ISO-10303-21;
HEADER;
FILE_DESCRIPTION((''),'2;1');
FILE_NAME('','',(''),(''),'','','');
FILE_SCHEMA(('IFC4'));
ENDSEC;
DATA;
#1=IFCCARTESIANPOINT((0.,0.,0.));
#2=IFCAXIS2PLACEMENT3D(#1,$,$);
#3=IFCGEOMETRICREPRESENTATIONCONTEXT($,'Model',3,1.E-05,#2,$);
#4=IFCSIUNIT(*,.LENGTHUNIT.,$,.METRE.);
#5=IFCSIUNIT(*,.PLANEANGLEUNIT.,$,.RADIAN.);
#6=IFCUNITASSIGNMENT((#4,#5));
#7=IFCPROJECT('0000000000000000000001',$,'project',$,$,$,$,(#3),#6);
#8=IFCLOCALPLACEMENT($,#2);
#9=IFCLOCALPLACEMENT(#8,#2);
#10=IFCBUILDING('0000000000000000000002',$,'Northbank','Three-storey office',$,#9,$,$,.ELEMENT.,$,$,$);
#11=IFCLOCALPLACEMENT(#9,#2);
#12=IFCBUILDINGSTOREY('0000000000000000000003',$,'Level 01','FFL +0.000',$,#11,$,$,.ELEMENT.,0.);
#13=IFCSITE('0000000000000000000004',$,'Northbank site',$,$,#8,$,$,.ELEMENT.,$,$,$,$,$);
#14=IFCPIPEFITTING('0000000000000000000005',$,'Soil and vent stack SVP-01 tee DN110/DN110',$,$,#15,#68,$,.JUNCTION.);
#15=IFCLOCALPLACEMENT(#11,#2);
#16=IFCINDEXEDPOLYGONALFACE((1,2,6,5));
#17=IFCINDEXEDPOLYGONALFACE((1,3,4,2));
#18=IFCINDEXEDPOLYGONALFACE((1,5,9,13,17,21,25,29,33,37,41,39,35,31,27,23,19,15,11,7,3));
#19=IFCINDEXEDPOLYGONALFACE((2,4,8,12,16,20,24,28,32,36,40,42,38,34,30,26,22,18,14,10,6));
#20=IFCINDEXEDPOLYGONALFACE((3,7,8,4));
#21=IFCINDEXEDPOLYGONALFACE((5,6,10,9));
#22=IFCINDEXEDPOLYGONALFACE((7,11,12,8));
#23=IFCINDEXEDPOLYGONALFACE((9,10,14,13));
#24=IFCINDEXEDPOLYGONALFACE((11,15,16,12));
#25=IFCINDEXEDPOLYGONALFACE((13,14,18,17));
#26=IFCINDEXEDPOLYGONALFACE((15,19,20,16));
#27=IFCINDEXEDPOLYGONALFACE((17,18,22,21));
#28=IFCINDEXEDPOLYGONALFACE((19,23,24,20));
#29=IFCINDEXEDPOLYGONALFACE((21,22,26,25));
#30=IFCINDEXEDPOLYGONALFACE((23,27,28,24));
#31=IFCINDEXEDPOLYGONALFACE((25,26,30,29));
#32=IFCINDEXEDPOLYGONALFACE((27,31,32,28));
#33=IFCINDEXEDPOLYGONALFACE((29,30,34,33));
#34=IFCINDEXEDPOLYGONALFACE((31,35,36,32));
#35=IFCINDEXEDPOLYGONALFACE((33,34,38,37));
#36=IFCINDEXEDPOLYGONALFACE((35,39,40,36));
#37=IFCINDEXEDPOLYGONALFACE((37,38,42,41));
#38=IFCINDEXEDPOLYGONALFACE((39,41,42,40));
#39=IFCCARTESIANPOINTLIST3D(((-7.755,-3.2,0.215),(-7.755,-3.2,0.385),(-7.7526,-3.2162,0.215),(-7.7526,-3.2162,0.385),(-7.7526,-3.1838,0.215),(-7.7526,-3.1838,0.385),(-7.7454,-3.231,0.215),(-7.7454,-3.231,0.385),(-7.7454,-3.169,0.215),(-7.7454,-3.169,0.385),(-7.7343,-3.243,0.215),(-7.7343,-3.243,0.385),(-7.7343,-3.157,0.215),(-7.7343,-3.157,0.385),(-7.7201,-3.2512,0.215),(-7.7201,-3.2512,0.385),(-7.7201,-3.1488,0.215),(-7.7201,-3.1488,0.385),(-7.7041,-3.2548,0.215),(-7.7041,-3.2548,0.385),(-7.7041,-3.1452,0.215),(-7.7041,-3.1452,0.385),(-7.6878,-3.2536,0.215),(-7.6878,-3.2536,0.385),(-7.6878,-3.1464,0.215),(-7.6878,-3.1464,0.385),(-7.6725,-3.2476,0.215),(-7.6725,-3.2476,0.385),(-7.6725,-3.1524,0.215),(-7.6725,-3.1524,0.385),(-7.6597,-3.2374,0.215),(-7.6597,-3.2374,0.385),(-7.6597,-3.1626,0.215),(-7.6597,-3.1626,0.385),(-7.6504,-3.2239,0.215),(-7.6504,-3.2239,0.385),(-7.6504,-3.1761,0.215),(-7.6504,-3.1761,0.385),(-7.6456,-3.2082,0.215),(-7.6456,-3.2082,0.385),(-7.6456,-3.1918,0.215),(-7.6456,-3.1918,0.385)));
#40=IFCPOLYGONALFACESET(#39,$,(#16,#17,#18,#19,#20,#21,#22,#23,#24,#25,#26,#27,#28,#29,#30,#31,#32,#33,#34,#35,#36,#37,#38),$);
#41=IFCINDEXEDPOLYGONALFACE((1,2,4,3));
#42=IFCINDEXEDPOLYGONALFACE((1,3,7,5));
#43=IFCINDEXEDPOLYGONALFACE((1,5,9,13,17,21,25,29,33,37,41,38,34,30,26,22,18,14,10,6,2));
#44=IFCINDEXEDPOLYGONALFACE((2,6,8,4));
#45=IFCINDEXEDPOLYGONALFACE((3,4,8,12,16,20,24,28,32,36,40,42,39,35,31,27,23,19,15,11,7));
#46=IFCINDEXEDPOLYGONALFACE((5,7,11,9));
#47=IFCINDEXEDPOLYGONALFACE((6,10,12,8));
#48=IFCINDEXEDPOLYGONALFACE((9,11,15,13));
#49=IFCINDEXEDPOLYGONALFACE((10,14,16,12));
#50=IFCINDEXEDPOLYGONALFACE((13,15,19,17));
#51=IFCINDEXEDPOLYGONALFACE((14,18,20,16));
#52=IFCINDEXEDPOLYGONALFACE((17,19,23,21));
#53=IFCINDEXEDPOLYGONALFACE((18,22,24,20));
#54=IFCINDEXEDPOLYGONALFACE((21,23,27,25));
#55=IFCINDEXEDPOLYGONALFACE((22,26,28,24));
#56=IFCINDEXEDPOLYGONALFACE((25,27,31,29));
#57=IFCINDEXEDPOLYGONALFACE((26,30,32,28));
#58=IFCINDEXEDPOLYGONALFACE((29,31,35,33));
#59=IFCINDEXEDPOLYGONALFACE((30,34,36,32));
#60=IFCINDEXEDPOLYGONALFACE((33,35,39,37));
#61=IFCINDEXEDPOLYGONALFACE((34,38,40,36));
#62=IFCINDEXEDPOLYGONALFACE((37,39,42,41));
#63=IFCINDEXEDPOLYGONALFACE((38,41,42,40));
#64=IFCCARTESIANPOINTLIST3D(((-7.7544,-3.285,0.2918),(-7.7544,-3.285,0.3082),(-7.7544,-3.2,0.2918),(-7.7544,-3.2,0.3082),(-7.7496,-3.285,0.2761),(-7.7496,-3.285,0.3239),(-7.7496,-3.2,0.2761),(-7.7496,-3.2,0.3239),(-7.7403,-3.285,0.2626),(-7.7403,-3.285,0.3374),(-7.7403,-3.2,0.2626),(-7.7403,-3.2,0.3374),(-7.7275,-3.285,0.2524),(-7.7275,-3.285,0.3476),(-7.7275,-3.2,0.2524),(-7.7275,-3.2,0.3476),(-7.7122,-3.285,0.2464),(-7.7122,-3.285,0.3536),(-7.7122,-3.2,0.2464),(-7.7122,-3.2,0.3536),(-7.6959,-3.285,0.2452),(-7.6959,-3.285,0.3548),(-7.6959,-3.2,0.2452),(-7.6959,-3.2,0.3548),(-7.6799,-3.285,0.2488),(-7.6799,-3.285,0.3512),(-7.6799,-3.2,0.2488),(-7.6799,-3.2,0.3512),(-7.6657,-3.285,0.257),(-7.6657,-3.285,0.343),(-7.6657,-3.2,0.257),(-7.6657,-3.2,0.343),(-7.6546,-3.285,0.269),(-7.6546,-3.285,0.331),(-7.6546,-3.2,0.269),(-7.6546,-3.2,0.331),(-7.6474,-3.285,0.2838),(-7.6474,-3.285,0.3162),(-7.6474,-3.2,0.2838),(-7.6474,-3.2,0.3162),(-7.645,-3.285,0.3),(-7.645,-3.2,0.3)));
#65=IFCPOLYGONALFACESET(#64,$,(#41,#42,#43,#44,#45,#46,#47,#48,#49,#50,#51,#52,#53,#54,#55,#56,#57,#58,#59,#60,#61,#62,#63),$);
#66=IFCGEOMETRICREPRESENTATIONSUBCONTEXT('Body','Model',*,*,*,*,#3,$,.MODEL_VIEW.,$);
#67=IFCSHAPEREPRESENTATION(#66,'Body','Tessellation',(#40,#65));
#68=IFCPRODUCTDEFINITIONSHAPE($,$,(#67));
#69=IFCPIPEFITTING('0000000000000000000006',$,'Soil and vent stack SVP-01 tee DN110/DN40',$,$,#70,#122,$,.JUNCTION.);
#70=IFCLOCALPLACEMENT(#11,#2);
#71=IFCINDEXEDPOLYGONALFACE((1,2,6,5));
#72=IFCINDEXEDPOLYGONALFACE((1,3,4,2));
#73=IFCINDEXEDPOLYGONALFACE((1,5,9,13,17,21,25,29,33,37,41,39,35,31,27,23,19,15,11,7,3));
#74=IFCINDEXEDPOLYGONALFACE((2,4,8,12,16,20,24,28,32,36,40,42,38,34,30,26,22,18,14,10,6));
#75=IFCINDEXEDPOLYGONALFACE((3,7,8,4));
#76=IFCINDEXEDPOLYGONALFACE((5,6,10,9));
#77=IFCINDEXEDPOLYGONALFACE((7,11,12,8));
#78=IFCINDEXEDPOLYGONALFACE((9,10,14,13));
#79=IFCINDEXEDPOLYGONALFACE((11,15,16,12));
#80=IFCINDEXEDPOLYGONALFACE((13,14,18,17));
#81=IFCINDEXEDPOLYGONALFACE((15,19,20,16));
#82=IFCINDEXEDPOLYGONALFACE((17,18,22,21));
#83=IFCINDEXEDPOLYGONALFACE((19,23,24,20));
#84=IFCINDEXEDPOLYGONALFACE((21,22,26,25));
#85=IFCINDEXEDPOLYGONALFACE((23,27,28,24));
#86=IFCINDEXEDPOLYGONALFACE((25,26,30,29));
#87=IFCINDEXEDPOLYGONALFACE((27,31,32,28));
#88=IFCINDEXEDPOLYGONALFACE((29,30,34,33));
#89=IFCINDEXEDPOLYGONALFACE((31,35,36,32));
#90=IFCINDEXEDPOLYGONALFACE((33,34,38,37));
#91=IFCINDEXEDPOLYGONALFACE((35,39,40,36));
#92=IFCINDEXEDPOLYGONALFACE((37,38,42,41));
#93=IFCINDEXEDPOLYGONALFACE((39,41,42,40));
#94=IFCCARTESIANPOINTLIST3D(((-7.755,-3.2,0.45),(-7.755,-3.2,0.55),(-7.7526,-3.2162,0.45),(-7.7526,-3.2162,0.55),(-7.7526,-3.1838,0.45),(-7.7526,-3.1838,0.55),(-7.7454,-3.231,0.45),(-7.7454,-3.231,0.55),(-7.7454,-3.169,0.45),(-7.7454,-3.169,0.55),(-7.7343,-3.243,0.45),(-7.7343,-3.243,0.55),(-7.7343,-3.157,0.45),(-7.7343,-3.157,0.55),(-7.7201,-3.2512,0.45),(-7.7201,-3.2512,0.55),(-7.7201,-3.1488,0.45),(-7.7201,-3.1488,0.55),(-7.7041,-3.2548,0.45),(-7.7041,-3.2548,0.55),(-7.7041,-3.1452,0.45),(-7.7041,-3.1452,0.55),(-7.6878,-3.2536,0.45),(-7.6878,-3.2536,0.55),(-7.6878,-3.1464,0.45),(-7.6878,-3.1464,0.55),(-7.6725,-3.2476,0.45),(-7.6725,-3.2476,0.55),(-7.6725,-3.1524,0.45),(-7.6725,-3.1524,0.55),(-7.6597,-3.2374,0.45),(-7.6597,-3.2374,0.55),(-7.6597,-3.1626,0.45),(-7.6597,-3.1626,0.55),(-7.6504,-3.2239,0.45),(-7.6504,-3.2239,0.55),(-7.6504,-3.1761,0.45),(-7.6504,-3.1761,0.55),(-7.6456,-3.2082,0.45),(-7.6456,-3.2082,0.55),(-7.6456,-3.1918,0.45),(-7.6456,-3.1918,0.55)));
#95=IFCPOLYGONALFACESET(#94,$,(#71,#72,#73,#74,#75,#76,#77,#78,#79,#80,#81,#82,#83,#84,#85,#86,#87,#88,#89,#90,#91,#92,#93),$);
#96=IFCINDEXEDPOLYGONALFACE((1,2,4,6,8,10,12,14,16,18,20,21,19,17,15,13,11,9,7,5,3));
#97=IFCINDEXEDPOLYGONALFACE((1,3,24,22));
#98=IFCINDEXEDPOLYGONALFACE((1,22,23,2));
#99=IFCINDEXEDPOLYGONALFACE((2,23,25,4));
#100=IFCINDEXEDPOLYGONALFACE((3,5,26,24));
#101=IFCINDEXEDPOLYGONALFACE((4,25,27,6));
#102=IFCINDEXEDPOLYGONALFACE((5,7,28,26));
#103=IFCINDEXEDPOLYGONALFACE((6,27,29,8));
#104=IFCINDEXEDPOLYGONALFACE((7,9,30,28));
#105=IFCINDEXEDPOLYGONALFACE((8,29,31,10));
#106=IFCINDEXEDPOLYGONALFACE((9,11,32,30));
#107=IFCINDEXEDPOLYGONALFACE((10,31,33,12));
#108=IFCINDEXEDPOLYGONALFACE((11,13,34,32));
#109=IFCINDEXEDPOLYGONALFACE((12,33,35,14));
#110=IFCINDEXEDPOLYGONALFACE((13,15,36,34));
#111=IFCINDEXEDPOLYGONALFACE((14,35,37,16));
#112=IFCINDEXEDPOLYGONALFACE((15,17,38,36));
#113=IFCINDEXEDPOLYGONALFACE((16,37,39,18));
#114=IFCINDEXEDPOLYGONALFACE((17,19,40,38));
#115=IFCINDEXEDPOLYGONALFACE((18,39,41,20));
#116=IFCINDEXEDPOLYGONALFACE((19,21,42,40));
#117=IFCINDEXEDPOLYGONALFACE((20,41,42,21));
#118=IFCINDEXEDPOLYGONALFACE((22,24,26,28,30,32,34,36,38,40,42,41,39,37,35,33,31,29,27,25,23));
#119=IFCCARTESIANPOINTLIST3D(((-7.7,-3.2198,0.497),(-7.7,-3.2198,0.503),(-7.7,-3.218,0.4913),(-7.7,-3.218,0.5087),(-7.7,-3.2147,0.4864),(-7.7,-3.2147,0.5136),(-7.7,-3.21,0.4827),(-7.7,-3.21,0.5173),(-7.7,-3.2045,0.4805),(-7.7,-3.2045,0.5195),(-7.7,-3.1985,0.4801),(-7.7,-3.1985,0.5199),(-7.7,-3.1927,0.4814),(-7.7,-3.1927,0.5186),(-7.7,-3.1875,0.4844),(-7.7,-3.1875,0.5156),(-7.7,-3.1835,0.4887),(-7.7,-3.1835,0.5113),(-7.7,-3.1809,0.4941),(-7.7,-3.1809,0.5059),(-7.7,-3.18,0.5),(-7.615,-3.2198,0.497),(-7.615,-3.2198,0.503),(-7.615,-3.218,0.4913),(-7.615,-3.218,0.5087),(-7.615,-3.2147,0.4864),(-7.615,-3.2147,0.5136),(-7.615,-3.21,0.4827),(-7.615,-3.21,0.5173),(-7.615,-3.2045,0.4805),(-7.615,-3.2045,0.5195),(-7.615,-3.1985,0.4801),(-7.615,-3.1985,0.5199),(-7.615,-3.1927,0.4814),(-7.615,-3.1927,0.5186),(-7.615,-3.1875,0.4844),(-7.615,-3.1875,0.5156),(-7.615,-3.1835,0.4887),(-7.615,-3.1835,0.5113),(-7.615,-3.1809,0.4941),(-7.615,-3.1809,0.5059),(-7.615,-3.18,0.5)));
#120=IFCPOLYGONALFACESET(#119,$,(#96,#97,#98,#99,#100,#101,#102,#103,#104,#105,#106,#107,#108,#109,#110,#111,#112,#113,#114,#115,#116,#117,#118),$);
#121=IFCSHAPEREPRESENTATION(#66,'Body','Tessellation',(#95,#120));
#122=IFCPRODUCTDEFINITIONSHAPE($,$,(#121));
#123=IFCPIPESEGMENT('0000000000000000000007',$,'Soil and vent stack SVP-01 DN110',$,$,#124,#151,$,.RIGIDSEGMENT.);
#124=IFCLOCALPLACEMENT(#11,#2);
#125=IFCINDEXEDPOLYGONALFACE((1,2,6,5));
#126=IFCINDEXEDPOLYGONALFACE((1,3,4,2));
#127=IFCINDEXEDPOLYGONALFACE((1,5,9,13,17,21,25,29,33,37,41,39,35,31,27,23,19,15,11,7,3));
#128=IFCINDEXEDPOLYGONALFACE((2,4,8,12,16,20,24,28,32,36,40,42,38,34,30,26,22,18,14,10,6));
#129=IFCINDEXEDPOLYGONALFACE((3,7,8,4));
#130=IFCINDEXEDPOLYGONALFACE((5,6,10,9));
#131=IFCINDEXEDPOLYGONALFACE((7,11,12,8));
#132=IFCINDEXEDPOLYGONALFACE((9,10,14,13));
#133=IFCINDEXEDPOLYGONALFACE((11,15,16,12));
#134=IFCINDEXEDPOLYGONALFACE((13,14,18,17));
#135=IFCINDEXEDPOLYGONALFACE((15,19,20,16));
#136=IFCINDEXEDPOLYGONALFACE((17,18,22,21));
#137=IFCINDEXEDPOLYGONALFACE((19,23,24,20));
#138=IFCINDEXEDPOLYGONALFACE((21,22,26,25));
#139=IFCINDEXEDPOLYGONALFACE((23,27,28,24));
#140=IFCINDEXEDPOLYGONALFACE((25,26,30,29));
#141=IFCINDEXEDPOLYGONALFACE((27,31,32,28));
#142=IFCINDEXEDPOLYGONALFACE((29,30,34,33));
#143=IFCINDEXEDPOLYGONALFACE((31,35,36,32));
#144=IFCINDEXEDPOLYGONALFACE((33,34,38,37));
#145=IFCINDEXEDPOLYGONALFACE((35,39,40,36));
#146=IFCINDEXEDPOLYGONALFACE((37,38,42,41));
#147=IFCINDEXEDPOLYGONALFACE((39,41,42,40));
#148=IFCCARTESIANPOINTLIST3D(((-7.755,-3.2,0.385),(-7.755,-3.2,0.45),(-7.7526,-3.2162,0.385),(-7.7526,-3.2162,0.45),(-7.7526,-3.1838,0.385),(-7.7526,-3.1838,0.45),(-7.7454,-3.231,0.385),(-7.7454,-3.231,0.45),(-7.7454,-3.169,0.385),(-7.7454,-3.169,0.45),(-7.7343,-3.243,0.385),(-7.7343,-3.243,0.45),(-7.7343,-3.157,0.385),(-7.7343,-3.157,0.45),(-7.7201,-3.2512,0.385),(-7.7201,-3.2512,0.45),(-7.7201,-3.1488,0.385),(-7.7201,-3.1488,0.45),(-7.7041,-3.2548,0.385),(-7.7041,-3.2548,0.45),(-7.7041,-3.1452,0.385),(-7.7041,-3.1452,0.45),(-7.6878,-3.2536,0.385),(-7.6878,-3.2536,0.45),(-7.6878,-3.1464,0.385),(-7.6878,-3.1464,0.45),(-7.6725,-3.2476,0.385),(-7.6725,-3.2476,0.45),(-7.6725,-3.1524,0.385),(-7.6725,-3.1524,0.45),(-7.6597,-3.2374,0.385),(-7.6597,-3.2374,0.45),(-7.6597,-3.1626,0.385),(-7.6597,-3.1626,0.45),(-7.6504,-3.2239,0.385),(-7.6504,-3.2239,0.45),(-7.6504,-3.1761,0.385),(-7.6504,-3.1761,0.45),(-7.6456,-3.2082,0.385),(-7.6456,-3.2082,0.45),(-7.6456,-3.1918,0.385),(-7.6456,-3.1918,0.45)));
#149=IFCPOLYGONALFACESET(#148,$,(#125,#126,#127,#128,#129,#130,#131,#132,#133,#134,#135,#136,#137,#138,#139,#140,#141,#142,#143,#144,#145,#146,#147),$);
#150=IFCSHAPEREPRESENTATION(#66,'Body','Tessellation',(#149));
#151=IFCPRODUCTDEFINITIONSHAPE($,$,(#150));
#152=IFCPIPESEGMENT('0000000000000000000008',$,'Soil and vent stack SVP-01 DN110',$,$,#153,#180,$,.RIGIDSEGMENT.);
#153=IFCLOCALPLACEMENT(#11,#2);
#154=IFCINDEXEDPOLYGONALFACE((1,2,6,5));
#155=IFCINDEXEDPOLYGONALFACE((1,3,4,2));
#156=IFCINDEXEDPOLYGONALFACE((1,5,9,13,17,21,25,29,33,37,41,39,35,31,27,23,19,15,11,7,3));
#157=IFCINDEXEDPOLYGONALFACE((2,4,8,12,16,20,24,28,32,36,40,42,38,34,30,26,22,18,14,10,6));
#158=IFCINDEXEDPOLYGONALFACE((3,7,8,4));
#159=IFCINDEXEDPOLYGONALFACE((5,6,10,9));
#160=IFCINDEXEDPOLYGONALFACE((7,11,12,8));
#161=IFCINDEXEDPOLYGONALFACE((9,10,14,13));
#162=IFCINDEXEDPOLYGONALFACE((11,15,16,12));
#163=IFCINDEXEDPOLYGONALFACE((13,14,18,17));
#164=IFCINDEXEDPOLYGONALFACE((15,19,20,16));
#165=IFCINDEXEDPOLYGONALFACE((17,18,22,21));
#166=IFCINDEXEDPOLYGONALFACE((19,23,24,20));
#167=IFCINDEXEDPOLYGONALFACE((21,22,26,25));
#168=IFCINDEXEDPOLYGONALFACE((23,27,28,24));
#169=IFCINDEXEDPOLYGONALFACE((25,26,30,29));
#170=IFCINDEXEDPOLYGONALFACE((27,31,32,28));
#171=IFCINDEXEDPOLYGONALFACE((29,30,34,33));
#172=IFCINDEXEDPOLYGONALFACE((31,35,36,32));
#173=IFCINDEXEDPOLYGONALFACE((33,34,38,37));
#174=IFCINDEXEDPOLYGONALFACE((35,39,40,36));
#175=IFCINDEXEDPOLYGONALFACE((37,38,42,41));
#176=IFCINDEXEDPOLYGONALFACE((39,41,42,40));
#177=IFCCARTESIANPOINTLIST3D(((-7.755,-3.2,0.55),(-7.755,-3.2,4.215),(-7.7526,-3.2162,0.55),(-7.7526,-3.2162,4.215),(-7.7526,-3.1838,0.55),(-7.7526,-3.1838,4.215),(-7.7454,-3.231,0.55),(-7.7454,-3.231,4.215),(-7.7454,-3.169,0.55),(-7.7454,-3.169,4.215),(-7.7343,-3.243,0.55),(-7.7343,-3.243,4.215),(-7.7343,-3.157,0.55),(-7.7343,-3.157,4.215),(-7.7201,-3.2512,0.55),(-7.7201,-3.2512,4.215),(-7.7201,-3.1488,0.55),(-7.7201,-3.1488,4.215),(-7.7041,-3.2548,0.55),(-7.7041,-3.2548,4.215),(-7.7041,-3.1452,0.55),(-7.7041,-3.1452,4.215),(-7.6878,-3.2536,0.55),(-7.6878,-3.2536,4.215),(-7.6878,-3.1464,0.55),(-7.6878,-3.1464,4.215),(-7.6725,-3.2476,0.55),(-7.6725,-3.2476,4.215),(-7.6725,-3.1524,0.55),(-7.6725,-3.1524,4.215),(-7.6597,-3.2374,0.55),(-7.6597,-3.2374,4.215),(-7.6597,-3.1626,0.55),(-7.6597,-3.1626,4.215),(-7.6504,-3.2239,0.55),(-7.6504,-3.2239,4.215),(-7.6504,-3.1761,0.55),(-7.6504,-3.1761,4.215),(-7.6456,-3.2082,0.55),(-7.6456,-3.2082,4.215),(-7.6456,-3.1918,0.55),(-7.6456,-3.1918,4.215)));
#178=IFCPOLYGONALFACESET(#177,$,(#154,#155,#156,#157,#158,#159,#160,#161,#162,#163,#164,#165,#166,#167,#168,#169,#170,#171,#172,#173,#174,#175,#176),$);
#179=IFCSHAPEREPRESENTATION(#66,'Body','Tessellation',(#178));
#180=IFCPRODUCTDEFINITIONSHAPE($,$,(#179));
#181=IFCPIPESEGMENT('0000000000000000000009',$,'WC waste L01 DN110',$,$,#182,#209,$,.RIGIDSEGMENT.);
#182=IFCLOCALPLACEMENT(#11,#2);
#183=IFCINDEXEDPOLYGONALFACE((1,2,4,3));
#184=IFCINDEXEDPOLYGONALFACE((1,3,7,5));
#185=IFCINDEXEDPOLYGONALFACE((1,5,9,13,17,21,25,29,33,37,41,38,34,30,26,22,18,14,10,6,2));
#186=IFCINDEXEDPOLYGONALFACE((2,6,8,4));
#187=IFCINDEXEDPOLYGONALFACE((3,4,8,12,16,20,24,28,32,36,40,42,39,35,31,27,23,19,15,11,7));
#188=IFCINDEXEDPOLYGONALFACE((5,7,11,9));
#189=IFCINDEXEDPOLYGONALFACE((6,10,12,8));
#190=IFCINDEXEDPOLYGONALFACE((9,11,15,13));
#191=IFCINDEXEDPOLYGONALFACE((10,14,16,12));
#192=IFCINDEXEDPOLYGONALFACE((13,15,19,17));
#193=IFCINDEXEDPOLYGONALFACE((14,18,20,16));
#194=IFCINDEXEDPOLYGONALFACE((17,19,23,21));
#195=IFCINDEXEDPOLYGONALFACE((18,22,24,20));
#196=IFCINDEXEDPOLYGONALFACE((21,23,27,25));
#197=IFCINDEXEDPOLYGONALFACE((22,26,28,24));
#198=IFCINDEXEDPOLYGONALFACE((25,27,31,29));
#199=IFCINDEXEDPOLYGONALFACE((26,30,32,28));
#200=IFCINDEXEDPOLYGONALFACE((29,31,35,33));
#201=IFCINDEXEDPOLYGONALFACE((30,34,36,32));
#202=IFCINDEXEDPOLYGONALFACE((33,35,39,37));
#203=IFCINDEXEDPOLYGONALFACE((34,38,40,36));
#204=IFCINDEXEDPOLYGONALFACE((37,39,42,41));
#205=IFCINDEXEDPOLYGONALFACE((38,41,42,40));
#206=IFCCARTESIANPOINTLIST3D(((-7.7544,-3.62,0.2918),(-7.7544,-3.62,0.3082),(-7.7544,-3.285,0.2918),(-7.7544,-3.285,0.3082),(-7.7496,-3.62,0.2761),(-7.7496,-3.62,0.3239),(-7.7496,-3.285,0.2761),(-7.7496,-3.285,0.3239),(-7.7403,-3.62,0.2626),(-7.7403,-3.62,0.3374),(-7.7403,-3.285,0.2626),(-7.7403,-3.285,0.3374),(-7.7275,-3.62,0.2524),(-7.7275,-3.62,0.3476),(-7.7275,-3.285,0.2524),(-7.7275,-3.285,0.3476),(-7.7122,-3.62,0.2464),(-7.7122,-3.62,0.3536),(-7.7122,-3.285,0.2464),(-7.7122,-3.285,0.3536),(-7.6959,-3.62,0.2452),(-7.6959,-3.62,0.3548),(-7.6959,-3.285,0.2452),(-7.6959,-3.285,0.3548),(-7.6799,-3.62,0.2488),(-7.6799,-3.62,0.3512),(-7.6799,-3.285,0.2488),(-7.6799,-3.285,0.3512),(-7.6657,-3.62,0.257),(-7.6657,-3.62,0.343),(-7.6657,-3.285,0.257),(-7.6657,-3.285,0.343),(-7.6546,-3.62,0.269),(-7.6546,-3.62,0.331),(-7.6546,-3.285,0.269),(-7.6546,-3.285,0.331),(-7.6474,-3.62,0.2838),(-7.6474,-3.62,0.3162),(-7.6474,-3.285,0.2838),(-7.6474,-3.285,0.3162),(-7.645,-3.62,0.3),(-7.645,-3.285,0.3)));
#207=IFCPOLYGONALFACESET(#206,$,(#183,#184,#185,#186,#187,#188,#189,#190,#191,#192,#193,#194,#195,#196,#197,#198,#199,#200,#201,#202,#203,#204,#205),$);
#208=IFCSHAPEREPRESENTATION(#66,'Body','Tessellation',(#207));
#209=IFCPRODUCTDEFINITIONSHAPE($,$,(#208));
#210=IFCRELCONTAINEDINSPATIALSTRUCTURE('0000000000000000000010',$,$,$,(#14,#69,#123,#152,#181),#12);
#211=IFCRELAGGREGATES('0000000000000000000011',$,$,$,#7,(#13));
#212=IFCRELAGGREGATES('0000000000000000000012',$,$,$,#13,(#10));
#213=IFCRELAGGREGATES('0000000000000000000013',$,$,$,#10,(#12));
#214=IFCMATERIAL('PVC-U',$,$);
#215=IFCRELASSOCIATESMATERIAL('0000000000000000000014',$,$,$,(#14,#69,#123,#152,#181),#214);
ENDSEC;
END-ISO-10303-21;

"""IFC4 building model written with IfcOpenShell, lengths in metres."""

from ifc_helpers import new_model, si_unit, frame, origin, place, context, subcontext, project, spatial, circle, extrude, material, element, save


model = new_model("IFC4")

# Units and contexts
model_context = context("Model", 3, precision=1e-05, world=origin())
body_context = subcontext(model_context, "Body", "Model", "MODEL_VIEW")
ifc_project = project(units=[si_unit("LENGTHUNIT", "METRE"), si_unit("PLANEANGLEUNIT", "RADIAN")], contexts=[model_context])

# Site, building, storey
site_placement = place(None, origin())
site = spatial("IfcSite", under=ifc_project, at=site_placement, Name="Northbank site", CompositionType="ELEMENT")
building_placement = place(site_placement, origin())
building = spatial("IfcBuilding", under=site, at=building_placement, Name="Northbank", Description="Three-storey office", CompositionType="ELEMENT")
storey_placement = place(building_placement, origin())
storey = spatial("IfcBuildingStorey", under=building, at=storey_placement, Name="Level 01", Description="FFL +0.000", CompositionType="ELEMENT", Elevation=0.0)

# Pipe fittings
ifc_material_1 = material(Name="PVC-U")
pipe_fitting_1_placement = place(storey_placement, origin())
element("IfcPipeFitting", 1, at=pipe_fitting_1_placement, inside=storey, material=ifc_material_1, Name="Soil and vent stack SVP-01 tee DN110/DN110", PredefinedType="JUNCTION", context=body_context, shape_type="SweptSolid", body=[
    extrude(circle(Radius=0.055), frame((-7.7, -3.2, 0.215), z_axis=(0.0, 0.0, 1.0), x_axis=(-1.0, 0.0, 0.0)), (0.0, 0.0, 1.0), 0.17),
    extrude(circle(Radius=0.055), frame((-7.7, -3.2, 0.3), z_axis=(0.0, -1.0, 0.0), x_axis=(1.0, 0.0, 0.0)), (0.0, 0.0, 1.0), 0.085),
])
pipe_fitting_2_placement = place(storey_placement, origin())
element("IfcPipeFitting", 2, at=pipe_fitting_2_placement, inside=storey, material=ifc_material_1, Name="Soil and vent stack SVP-01 tee DN110/DN40", PredefinedType="JUNCTION", context=body_context, shape_type="SweptSolid", body=[
    extrude(circle(Radius=0.055), frame((-7.7, -3.2, 0.45), z_axis=(0.0, 0.0, 1.0), x_axis=(-1.0, 0.0, 0.0)), (0.0, 0.0, 1.0), 0.1),
    extrude(circle(Radius=0.02), frame((-7.7, -3.2, 0.5), z_axis=(1.0, 0.0, 0.0), x_axis=(0.0, 1.0, 0.0)), (0.0, 0.0, 1.0), 0.085),
])

# Pipe segments
pipe_segment_1_placement = place(storey_placement, origin())
element("IfcPipeSegment", 3, at=pipe_segment_1_placement, inside=storey, material=ifc_material_1, Name="Soil and vent stack SVP-01 DN110", PredefinedType="RIGIDSEGMENT", context=body_context, shape_type="SweptSolid", body=[
    extrude(circle(Radius=0.055), frame((-7.7, -3.2, 0.385), z_axis=(0.0, 0.0, 1.0), x_axis=(-1.0, 0.0, 0.0)), (0.0, 0.0, 1.0), 0.065),
])
pipe_segment_2_placement = place(storey_placement, origin())
element("IfcPipeSegment", 4, at=pipe_segment_2_placement, inside=storey, material=ifc_material_1, Name="Soil and vent stack SVP-01 DN110", PredefinedType="RIGIDSEGMENT", context=body_context, shape_type="SweptSolid", body=[
    extrude(circle(Radius=0.055), frame((-7.7, -3.2, 0.55), z_axis=(0.0, 0.0, 1.0), x_axis=(-1.0, 0.0, 0.0)), (0.0, 0.0, 1.0), 3.665),
])
pipe_segment_3_placement = place(storey_placement, origin())
element("IfcPipeSegment", 5, at=pipe_segment_3_placement, inside=storey, material=ifc_material_1, Name="WC waste L01 DN110", PredefinedType="RIGIDSEGMENT", context=body_context, shape_type="SweptSolid", body=[
    extrude(circle(Radius=0.055), frame((-7.7, -3.285, 0.3), z_axis=(0.0, -1.0, 0.0), x_axis=(1.0, 0.0, 0.0)), (0.0, 0.0, 1.0), 0.335),
])

save(model, "model.ifc")
